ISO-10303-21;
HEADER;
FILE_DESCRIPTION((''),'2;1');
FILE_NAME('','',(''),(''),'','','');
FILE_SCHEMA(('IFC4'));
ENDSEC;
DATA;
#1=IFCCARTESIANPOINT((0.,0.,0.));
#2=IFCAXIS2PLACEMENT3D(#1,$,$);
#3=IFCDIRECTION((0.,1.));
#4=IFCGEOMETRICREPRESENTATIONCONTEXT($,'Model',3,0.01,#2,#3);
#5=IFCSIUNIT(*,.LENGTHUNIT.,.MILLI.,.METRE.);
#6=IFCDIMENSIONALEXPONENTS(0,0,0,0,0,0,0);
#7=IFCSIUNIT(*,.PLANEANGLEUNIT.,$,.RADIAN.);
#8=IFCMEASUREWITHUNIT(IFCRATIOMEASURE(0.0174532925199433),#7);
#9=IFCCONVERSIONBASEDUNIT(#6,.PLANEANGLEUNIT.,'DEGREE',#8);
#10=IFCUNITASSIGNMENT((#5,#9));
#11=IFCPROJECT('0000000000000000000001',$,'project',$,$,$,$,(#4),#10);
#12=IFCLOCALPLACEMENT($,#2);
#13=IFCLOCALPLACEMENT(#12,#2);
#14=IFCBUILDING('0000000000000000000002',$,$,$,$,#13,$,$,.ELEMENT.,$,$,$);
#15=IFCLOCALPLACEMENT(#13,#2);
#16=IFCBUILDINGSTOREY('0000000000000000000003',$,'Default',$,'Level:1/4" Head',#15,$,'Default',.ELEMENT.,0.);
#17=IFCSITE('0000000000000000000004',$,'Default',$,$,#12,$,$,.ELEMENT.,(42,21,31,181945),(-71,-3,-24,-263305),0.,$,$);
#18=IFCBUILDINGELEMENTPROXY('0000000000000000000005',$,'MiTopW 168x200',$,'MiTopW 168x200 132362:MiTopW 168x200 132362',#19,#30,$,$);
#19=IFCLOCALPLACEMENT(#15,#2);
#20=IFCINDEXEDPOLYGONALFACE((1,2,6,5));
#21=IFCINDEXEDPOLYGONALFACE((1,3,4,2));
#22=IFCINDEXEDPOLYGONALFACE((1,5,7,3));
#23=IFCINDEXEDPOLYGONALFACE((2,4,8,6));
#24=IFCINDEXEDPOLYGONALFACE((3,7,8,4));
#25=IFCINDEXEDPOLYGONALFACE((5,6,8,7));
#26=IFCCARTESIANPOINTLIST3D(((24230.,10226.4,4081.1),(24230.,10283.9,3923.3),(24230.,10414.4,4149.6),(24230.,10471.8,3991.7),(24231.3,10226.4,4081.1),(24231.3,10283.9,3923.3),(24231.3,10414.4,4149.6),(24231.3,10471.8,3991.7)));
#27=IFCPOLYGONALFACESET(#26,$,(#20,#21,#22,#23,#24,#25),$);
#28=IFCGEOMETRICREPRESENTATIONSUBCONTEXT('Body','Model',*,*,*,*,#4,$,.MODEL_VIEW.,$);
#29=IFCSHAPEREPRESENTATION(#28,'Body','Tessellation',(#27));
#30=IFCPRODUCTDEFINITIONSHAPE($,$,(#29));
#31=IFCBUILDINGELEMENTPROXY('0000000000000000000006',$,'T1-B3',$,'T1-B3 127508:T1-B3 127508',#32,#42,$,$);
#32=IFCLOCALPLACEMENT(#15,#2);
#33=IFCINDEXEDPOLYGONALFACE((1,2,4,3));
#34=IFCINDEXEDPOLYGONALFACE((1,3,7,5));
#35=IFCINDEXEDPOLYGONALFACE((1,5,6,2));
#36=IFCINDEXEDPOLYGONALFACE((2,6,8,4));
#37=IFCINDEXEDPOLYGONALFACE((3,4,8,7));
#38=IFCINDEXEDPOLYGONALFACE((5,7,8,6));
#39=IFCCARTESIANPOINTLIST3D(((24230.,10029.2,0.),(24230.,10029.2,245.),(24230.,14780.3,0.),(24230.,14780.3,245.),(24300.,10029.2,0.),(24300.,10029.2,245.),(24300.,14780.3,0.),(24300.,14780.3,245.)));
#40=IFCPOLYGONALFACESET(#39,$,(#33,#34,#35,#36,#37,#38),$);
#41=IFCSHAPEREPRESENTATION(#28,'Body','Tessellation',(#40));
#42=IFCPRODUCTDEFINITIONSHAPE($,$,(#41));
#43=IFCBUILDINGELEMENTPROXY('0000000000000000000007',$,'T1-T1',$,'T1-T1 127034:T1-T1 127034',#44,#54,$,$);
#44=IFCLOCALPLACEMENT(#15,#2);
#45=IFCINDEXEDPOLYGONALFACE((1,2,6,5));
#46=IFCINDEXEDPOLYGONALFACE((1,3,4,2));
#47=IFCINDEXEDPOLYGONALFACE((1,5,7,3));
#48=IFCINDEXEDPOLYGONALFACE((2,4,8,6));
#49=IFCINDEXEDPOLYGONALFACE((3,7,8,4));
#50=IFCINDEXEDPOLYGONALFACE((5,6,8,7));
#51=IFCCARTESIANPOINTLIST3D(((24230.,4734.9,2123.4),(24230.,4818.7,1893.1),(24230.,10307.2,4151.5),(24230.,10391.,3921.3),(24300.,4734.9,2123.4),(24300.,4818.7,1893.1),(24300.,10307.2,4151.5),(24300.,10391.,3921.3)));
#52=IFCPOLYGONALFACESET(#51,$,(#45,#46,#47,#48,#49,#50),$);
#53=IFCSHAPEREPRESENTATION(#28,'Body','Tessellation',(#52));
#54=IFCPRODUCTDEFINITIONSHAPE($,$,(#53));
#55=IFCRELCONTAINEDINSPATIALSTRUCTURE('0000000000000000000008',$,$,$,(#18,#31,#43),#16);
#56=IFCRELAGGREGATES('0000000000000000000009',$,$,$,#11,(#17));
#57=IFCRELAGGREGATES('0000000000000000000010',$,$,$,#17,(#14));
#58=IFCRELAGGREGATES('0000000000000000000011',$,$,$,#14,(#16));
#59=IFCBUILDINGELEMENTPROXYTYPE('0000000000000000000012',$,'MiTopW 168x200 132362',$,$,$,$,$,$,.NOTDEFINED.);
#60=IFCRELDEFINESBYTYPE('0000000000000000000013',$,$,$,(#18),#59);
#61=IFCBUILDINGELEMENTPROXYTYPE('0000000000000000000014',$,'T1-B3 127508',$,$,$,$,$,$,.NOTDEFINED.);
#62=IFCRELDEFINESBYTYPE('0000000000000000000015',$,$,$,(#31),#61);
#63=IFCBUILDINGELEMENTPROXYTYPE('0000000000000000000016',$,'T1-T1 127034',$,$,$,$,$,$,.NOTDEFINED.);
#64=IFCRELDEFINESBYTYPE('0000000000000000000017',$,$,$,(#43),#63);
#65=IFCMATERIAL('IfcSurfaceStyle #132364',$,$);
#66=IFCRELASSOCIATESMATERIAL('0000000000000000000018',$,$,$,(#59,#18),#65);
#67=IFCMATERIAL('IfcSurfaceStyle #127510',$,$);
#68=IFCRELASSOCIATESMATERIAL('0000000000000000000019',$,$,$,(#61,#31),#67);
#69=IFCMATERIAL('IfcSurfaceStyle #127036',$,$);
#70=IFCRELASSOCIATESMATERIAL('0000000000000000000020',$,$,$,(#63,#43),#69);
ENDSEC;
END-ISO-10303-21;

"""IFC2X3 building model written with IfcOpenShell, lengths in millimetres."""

from ifc_helpers import new_model, entity, si_unit, converted_unit, direction, frame, origin, origin_2d_with_axis, place, context, subcontext, project, spatial, polyline, rectangle, outline, extrude, source, transform, mapped, material, type_object, type_shapes, element, save


model = new_model("IFC2X3")

# Units and contexts
model_context = context("Model", 3, precision=0.01, world=origin(), true_north=direction((0.0, 1.0)))
body_context = subcontext(model_context, "Body", "Model", "MODEL_VIEW")
ifc_project = project(units=[si_unit("LENGTHUNIT", "METRE", prefix="MILLI"), converted_unit("PLANEANGLEUNIT", "DEGREE", entity("IfcRatioMeasure", 0.0174532925199433), si_unit("PLANEANGLEUNIT", "RADIAN"), dimensions=[0, 0, 0, 0, 0, 0, 0])], contexts=[model_context])

# Site, building, storey
site_placement = place(None, origin())
site = spatial("IfcSite", under=ifc_project, at=site_placement, Name="Default", CompositionType="ELEMENT", RefLatitude=(42, 21, 31, 181945), RefLongitude=(-71, -3, -24, -263305), RefElevation=0.0)
building_placement = place(site_placement, origin())
building = spatial("IfcBuilding", under=site, at=building_placement, CompositionType="ELEMENT")
storey_placement = place(building_placement, origin())
storey = spatial("IfcBuildingStorey", under=building, at=storey_placement, Name="Default", ObjectType="Level:1/4\" Head", LongName="Default", CompositionType="ELEMENT", Elevation=0.0)

# Building element proxies
ifc_material_1 = material(Name="IfcSurfaceStyle #132364")
building_element_proxy_type_1 = type_object("IfcBuildingElementProxyType", Name="MiTopW 168x200 132362", PredefinedType="NOTDEFINED", material=ifc_material_1)
shared_shape_1 = source(origin(), body_context, "Body", "SweptSolid", [
    extrude(outline(polyline([(-100.0, -84.0), (100.0, -84.0), (100.0, 84.0), (-100.0, 84.0), (-100.0, -84.0)])), frame((100.0, 84.0, 0.0), z_axis=(0.0, 0.0, 1.0), x_axis=(-1.0, 0.0, 0.0)), (0.0, 0.0, 1.0), 1.3),
])
type_shapes(building_element_proxy_type_1, [shared_shape_1])
proxy_1_placement = place(building_placement, frame((24231.3, 10226.4, 4081.1), z_axis=(-1.0, 0.0, 0.0), x_axis=(0.0, 0.939693, 0.34202)))
element("IfcBuildingElementProxy", 1, at=proxy_1_placement, inside=storey, type_object=building_element_proxy_type_1, material=ifc_material_1, Name="MiTopW 168x200", ObjectType="MiTopW 168x200 132362:MiTopW 168x200 132362", context=body_context, shape_type="MappedRepresentation", body=[
    mapped(shared_shape_1, transform((0.0, 0.0, 0.0), scale=1.0)),
])
ifc_material_2 = material(Name="IfcSurfaceStyle #127510")
building_element_proxy_type_2 = type_object("IfcBuildingElementProxyType", Name="T1-B3 127508", PredefinedType="NOTDEFINED", material=ifc_material_2)
shared_shape_2 = source(origin(), body_context, "Body", "SweptSolid", [
    extrude(rectangle(XDim=4751.0, YDim=245.0, at=origin_2d_with_axis()), frame((2375.5, 122.5, 0.0), z_axis=(0.0, 0.0, 1.0), x_axis=(-1.0, 0.0, 0.0)), (0.0, 0.0, 1.0), 70.0),
])
type_shapes(building_element_proxy_type_2, [shared_shape_2])
proxy_2_placement = place(building_placement, frame((24300.0, 10029.2, 245.0), z_axis=(-1.0, 0.0, 0.0), x_axis=(0.0, 1.0, 0.0)))
element("IfcBuildingElementProxy", 2, at=proxy_2_placement, inside=storey, type_object=building_element_proxy_type_2, material=ifc_material_2, Name="T1-B3", ObjectType="T1-B3 127508:T1-B3 127508", context=body_context, shape_type="MappedRepresentation", body=[
    mapped(shared_shape_2, transform((0.0, 0.0, 0.0), scale=1.0)),
])
ifc_material_3 = material(Name="IfcSurfaceStyle #127036")
building_element_proxy_type_3 = type_object("IfcBuildingElementProxyType", Name="T1-T1 127034", PredefinedType="NOTDEFINED", material=ifc_material_3)
shared_shape_3 = source(origin(), body_context, "Body", "SweptSolid", [
    extrude(outline(polyline([(-2965.0, -122.5), (2965.0, -122.5), (2965.0, 122.5), (-2965.0, 122.5), (-2965.0, -122.5)])), frame((2965.0, 122.5, 0.0), z_axis=(0.0, 0.0, 1.0), x_axis=(-1.0, 0.0, 0.0)), (0.0, 0.0, 1.0), 70.0),
])
type_shapes(building_element_proxy_type_3, [shared_shape_3])
proxy_3_placement = place(building_placement, frame((24300.0, 10391.0, 3921.3), z_axis=(-1.0, 0.0, 0.0), x_axis=(0.0, -0.939693, -0.34202)))
element("IfcBuildingElementProxy", 3, at=proxy_3_placement, inside=storey, type_object=building_element_proxy_type_3, material=ifc_material_3, Name="T1-T1", ObjectType="T1-T1 127034:T1-T1 127034", context=body_context, shape_type="MappedRepresentation", body=[
    mapped(shared_shape_3, transform((0.0, 0.0, 0.0), scale=1.0)),
])

save(model, "model.ifc")
